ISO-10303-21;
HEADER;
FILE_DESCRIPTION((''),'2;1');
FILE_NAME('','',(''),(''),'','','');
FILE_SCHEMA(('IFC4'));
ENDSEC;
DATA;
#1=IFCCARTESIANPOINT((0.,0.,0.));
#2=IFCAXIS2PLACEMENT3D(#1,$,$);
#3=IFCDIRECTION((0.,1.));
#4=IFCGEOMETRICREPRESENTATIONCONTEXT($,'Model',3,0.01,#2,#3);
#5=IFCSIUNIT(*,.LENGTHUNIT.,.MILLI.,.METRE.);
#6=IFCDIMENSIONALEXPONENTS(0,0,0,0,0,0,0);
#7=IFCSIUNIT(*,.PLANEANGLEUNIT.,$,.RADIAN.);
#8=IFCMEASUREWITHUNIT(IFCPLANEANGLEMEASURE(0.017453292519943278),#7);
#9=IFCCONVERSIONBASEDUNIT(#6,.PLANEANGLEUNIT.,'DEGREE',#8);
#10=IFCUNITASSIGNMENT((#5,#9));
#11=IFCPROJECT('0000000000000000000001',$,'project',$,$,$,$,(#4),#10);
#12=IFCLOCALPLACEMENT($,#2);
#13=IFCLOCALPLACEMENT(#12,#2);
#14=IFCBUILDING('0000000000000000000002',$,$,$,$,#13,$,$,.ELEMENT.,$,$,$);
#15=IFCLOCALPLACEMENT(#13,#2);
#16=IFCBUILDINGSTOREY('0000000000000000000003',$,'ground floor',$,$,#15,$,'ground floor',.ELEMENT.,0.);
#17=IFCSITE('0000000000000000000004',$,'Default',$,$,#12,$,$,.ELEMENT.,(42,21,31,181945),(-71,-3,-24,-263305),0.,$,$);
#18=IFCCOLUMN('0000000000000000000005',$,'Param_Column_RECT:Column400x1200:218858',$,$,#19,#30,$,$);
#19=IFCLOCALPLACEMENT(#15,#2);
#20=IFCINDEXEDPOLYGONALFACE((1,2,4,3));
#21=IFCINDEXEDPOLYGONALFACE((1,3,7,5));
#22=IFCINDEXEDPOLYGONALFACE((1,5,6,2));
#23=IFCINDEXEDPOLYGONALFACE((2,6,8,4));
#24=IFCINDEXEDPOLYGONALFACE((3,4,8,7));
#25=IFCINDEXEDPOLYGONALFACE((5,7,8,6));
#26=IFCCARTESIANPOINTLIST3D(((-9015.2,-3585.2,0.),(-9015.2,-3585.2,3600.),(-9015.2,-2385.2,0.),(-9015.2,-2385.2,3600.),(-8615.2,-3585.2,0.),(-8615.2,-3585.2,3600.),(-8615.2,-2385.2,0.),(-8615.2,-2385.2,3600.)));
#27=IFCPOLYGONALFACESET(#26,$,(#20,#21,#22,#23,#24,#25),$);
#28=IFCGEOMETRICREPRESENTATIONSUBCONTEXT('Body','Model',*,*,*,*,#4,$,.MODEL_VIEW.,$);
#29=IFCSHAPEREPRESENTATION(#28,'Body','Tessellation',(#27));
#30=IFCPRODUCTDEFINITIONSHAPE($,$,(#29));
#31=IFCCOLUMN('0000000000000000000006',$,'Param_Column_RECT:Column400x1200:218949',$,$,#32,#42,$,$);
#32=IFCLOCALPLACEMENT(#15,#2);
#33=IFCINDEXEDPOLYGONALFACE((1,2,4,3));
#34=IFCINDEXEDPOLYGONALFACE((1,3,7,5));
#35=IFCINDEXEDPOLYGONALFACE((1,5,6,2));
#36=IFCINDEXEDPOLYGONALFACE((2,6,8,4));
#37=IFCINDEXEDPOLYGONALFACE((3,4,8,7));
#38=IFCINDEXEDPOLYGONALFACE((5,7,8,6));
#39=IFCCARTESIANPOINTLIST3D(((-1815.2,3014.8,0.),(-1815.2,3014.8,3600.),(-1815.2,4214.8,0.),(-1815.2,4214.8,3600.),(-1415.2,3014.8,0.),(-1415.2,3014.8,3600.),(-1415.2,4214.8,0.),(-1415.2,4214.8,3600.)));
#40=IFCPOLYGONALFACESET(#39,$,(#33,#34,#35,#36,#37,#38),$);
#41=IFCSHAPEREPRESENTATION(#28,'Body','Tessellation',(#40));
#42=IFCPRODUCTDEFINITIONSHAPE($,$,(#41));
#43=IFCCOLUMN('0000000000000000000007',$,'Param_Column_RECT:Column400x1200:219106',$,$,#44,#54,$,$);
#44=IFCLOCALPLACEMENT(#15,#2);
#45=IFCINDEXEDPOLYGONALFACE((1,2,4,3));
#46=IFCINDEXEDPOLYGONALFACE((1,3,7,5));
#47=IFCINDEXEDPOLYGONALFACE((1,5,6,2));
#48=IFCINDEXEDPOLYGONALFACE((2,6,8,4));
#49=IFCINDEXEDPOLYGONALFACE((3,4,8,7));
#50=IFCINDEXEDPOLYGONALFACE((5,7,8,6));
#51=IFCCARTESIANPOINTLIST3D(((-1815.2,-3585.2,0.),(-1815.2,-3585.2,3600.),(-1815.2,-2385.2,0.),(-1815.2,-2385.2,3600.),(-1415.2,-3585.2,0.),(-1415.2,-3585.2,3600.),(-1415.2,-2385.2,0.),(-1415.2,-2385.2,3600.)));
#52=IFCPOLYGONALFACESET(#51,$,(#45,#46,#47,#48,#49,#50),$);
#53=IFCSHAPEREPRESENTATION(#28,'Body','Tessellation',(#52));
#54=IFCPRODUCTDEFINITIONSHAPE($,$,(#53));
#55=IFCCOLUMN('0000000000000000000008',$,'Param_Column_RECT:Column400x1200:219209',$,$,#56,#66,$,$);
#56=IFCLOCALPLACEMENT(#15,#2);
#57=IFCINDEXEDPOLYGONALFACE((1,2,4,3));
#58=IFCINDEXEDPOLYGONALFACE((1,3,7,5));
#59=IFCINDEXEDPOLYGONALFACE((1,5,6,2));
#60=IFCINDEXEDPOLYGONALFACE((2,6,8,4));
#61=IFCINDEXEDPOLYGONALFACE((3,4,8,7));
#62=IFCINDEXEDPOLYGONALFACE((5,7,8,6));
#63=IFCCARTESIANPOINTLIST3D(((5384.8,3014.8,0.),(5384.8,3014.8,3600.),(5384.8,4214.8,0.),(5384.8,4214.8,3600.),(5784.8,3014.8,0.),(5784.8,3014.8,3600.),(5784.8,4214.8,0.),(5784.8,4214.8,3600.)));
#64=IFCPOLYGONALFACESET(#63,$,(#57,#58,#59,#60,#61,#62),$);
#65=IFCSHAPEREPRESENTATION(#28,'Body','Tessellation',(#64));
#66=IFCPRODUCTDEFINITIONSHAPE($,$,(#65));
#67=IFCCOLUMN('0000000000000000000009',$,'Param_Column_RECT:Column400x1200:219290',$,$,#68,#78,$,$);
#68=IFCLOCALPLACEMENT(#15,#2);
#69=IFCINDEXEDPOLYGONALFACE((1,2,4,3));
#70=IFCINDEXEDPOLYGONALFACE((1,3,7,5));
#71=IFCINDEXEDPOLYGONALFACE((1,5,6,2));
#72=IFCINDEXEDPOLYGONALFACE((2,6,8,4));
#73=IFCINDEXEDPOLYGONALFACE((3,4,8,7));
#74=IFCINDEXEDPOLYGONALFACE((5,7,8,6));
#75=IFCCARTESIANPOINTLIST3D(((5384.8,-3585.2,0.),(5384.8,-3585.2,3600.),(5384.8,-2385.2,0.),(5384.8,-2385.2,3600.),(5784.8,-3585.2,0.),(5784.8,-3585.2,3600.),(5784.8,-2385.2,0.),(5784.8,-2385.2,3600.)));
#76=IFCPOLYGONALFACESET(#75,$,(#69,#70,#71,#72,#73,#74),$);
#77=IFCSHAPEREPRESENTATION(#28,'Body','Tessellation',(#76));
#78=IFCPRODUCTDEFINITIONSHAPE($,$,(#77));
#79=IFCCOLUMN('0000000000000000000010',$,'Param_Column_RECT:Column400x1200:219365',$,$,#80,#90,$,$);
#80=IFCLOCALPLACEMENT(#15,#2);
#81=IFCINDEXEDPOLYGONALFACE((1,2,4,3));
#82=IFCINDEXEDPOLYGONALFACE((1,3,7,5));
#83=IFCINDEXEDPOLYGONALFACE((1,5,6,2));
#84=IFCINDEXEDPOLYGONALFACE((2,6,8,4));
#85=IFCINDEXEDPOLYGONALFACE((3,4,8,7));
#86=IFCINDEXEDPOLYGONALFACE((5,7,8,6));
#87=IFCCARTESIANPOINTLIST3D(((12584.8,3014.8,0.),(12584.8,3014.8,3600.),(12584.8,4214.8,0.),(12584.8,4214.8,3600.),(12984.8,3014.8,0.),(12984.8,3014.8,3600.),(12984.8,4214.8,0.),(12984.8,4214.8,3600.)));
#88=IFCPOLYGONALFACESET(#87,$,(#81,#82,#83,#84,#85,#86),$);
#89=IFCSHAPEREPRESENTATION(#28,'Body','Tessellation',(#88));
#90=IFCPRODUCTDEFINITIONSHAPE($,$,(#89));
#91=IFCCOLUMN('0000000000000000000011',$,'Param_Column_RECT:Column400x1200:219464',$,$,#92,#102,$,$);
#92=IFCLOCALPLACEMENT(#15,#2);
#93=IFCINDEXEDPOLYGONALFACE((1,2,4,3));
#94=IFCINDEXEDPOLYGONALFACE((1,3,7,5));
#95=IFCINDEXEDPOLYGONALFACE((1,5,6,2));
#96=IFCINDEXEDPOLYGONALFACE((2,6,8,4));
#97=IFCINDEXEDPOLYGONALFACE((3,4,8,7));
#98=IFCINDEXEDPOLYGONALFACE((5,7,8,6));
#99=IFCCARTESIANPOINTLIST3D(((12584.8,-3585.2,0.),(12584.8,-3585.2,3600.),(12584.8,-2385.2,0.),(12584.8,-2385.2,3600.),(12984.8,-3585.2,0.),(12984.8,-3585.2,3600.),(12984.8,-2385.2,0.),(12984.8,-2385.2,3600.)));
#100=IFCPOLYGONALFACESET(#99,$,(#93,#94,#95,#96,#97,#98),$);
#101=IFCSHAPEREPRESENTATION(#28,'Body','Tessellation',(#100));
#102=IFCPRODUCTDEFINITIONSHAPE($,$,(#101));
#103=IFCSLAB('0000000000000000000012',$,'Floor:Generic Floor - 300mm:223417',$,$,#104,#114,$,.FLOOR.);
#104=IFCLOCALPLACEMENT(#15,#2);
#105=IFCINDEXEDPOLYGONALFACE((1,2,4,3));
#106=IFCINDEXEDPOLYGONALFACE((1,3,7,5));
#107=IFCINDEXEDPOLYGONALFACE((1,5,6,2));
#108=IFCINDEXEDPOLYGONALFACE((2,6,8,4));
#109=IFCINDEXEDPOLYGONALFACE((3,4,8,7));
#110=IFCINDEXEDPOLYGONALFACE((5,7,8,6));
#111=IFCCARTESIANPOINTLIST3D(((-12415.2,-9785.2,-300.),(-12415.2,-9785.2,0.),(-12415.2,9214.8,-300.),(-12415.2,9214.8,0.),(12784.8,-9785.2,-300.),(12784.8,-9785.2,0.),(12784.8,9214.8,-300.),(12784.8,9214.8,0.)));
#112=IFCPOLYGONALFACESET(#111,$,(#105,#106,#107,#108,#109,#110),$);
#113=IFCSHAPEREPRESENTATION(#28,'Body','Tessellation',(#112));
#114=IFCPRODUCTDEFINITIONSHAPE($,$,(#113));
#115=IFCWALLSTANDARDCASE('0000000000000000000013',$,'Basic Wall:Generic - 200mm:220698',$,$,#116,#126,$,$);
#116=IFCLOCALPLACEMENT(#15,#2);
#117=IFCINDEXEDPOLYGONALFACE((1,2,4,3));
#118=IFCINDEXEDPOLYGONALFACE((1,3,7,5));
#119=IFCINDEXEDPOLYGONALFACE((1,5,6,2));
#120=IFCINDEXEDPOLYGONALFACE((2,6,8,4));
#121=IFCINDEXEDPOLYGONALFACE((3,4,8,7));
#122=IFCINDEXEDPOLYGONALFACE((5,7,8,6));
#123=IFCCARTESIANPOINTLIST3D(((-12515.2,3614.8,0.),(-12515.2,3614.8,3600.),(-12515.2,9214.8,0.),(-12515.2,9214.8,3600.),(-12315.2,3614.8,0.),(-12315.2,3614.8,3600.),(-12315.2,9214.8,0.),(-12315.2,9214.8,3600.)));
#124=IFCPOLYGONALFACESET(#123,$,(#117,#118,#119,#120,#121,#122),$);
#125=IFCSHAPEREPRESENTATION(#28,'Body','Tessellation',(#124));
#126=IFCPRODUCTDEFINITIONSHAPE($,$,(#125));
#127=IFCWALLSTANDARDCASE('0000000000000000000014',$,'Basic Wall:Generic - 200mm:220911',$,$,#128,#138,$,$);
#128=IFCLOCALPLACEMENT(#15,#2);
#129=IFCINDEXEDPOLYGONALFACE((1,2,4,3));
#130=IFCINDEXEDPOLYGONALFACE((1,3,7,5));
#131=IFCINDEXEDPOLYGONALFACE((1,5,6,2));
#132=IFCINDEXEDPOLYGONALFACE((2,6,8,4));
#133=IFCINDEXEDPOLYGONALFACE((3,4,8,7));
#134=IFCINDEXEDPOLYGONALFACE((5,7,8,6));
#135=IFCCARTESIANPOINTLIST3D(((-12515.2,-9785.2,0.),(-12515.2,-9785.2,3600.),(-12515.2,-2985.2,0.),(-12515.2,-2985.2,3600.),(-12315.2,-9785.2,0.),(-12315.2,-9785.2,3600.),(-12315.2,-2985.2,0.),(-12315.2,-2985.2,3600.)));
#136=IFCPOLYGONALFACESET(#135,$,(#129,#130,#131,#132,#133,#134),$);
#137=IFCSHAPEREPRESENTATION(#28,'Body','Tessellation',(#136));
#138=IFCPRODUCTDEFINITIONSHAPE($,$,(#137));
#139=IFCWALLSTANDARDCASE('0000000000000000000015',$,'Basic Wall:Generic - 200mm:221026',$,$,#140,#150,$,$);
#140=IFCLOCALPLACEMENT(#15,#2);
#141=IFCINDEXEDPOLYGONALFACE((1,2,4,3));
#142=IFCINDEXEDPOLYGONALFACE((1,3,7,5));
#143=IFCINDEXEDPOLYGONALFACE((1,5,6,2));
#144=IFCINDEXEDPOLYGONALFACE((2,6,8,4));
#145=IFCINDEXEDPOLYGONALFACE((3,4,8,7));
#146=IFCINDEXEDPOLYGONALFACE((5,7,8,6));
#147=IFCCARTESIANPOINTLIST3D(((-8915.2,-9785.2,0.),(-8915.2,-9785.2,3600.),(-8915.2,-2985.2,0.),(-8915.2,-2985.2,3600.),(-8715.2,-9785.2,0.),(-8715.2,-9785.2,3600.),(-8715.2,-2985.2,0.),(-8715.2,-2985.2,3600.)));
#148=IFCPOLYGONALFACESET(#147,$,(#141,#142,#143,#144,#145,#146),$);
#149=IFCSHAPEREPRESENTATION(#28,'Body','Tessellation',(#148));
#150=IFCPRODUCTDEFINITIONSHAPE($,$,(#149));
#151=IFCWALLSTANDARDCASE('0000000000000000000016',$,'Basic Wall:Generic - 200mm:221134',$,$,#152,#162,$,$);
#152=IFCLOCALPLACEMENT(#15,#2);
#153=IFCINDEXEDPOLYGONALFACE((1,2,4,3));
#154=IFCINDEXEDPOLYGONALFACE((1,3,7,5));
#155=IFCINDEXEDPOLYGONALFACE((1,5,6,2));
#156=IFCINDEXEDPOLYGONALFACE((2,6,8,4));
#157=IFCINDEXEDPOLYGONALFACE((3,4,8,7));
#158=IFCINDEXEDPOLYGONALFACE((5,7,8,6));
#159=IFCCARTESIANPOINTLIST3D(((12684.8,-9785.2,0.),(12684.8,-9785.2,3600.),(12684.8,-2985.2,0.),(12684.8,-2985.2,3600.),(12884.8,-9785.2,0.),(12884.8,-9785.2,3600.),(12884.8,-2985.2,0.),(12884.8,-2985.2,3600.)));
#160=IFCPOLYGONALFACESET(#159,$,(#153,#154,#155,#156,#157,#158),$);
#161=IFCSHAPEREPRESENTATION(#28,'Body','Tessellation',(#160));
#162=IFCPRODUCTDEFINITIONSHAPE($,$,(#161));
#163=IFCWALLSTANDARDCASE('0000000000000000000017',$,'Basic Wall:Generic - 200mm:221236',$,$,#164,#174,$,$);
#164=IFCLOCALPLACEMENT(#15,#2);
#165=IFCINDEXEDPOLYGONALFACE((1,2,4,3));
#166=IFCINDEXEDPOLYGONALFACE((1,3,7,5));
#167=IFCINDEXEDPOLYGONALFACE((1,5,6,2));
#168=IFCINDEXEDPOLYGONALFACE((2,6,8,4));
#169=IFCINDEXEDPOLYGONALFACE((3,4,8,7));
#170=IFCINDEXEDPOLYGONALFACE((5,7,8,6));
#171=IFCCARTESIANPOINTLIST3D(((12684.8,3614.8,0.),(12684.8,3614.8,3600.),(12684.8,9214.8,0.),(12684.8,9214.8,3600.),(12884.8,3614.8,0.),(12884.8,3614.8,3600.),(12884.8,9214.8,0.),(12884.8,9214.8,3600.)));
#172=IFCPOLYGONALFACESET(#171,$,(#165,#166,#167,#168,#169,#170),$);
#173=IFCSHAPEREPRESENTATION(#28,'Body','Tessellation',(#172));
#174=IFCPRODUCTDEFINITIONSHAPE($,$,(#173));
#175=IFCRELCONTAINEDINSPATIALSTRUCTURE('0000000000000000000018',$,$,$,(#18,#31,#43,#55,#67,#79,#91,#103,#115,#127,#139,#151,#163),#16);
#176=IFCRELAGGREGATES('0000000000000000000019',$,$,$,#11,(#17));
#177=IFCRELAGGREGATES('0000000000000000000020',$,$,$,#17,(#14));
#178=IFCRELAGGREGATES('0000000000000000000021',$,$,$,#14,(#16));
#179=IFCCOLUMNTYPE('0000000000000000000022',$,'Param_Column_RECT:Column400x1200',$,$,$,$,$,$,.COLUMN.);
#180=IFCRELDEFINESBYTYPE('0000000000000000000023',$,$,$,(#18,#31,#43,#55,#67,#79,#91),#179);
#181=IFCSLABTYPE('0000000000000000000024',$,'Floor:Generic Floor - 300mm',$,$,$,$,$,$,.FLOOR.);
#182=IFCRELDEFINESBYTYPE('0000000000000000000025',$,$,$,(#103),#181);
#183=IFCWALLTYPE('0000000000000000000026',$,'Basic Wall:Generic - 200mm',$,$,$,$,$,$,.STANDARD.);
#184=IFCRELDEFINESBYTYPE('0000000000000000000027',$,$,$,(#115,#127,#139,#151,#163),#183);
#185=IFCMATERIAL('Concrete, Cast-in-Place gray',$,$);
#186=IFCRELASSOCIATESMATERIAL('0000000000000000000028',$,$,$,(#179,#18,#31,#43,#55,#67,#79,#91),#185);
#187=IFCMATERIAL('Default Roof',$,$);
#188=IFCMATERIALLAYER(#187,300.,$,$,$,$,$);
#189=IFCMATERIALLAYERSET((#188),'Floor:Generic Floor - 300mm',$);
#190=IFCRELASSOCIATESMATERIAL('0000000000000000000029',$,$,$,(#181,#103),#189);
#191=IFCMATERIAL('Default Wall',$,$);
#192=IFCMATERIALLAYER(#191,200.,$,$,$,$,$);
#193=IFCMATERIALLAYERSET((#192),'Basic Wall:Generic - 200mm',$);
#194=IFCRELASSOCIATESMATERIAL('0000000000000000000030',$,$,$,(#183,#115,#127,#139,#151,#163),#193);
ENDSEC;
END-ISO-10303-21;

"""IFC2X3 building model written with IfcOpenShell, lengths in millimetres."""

from ifc_helpers import new_model, entity, si_unit, converted_unit, direction, frame, frame_2d, origin, origin_2d_with_axis, place, context, subcontext, project, spatial, rectangle, extrude, source, transform, mapped, material, layer, layer_set, layer_usage, type_object, type_shapes, element, save


model = new_model("IFC2X3")

# Units and contexts
model_context = context("Model", 3, precision=0.01, world=origin(), true_north=direction((0.0, 1.0)))
body_context = subcontext(model_context, "Body", "Model", "MODEL_VIEW")
ifc_project = project(units=[si_unit("LENGTHUNIT", "METRE", prefix="MILLI"), converted_unit("PLANEANGLEUNIT", "DEGREE", entity("IfcPlaneAngleMeasure", 0.017453292519943278), si_unit("PLANEANGLEUNIT", "RADIAN"), dimensions=[0, 0, 0, 0, 0, 0, 0])], contexts=[model_context])

# Site, building, storey
site_placement = place(None, origin())
site = spatial("IfcSite", under=ifc_project, at=site_placement, Name="Default", CompositionType="ELEMENT", RefLatitude=(42, 21, 31, 181945), RefLongitude=(-71, -3, -24, -263305), RefElevation=0.0)
building_placement = place(site_placement, origin())
building = spatial("IfcBuilding", under=site, at=building_placement, CompositionType="ELEMENT")
storey_placement = place(building_placement, origin())
storey = spatial("IfcBuildingStorey", under=building, at=storey_placement, Name="ground floor", LongName="ground floor", CompositionType="ELEMENT", Elevation=0.0)

# Columns
ifc_material_1 = material(Name="Concrete, Cast-in-Place gray")
column_type_1 = type_object("IfcColumnType", Name="Param_Column_RECT:Column400x1200", PredefinedType="COLUMN", material=ifc_material_1)
shared_shape_1 = source(origin(), body_context, "Body", "SweptSolid", [
    extrude(rectangle(XDim=400.0, YDim=1200.0, at=origin_2d_with_axis()), frame((0.0, 0.0, 0.0), z_axis=(0.0, 0.0, 1.0), x_axis=(-1.0, 0.0, 0.0)), (0.0, 0.0, 1.0), 3600.0),
])
type_shapes(column_type_1, [shared_shape_1])
for number, where, name in (
    (1, (-8815.2, -2985.2, 0.0), "Param_Column_RECT:Column400x1200:218858"),
    (2, (-1615.2, 3614.8, 0.0), "Param_Column_RECT:Column400x1200:218949"),
    (3, (-1615.2, -2985.2, 0.0), "Param_Column_RECT:Column400x1200:219106"),
    (4, (5584.8, 3614.8, 0.0), "Param_Column_RECT:Column400x1200:219209"),
    (5, (5584.8, -2985.2, 0.0), "Param_Column_RECT:Column400x1200:219290"),
    (6, (12784.8, 3614.8, 0.0), "Param_Column_RECT:Column400x1200:219365"),
    (7, (12784.8, -2985.2, 0.0), "Param_Column_RECT:Column400x1200:219464"),
):
    element("IfcColumn", number, at=place(storey_placement, frame(where)), inside=storey, type_object=column_type_1, material=ifc_material_1, Name=name, context=body_context, shape_type="MappedRepresentation", body=[
        mapped(shared_shape_1, transform((0.0, 0.0, 0.0), scale=1.0)),
    ])

# Slab
ifc_material_2 = material(Name="Default Roof")
ifc_layer_1 = layer(ifc_material_2, 300.0)
ifc_layer_set_1 = layer_set([ifc_layer_1], Name="Floor:Generic Floor - 300mm")
ifc_layer_usage_1 = layer_usage(ifc_layer_set_1, "AXIS3", "POSITIVE", 0.0)
slab_type = type_object("IfcSlabType", Name="Floor:Generic Floor - 300mm", PredefinedType="FLOOR", material=ifc_layer_set_1)
slab_placement = place(storey_placement, origin())
element("IfcSlab", 8, at=slab_placement, inside=storey, type_object=slab_type, material=ifc_layer_usage_1, Name="Floor:Generic Floor - 300mm:223417", PredefinedType="FLOOR", context=body_context, shape_type="SweptSolid", body=[
    extrude(rectangle(XDim=19000.0, YDim=25200.0, at=origin_2d_with_axis()), frame((184.8, -285.2, 0.0), z_axis=(0.0, 0.0, -1.0), x_axis=(0.0, 1.0, 0.0)), (0.0, 0.0, 1.0), 300.0),
])

# Walls
ifc_material_3 = material(Name="Default Wall")
ifc_layer_2 = layer(ifc_material_3, 200.0)
ifc_layer_set_2 = layer_set([ifc_layer_2], Name="Basic Wall:Generic - 200mm")
ifc_layer_usage_2 = layer_usage(ifc_layer_set_2, "AXIS2", "NEGATIVE", 100.0)
wall_type = type_object("IfcWallType", Name="Basic Wall:Generic - 200mm", PredefinedType="STANDARD", material=ifc_layer_set_2)
wall_1_placement = place(storey_placement, frame((-12415.2, 3614.8, 0.0), z_axis=(0.0, 0.0, 1.0), x_axis=(0.0, 1.0, 0.0)))
element("IfcWallStandardCase", 9, at=wall_1_placement, inside=storey, type_object=wall_type, material=ifc_layer_usage_2, Name="Basic Wall:Generic - 200mm:220698", context=body_context, shape_type="SweptSolid", body=[
    extrude(rectangle(XDim=5600.0, YDim=200.0, at=frame_2d((2800.0, 0.0), x_axis=(-1.0, 0.0))), origin(), (0.0, 0.0, 1.0), 3600.0),
])
ifc_layer_usage_3 = layer_usage(ifc_layer_set_2, "AXIS2", "NEGATIVE", 100.0)
wall_2_placement = place(storey_placement, frame((-12415.2, -9785.2, 0.0), z_axis=(0.0, 0.0, 1.0), x_axis=(0.0, 1.0, 0.0)))
element("IfcWallStandardCase", 10, at=wall_2_placement, inside=storey, type_object=wall_type, material=ifc_layer_usage_3, Name="Basic Wall:Generic - 200mm:220911", context=body_context, shape_type="SweptSolid", body=[
    extrude(rectangle(XDim=6800.0, YDim=200.0, at=frame_2d((3400.0, 0.0), x_axis=(-1.0, 0.0))), origin(), (0.0, 0.0, 1.0), 3600.0),
])
ifc_layer_usage_4 = layer_usage(ifc_layer_set_2, "AXIS2", "NEGATIVE", 100.0)
wall_3_placement = place(storey_placement, frame((-8815.2, -9785.2, 0.0), z_axis=(0.0, 0.0, 1.0), x_axis=(0.0, 1.0, 0.0)))
element("IfcWallStandardCase", 11, at=wall_3_placement, inside=storey, type_object=wall_type, material=ifc_layer_usage_4, Name="Basic Wall:Generic - 200mm:221026", context=body_context, shape_type="SweptSolid", body=[
    extrude(rectangle(XDim=6800.0, YDim=200.0, at=frame_2d((3400.0, 0.0), x_axis=(-1.0, 0.0))), origin(), (0.0, 0.0, 1.0), 3600.0),
])
ifc_layer_usage_5 = layer_usage(ifc_layer_set_2, "AXIS2", "NEGATIVE", 100.0)
wall_4_placement = place(storey_placement, frame((12784.8, -9785.2, 0.0), z_axis=(0.0, 0.0, 1.0), x_axis=(0.0, 1.0, 0.0)))
element("IfcWallStandardCase", 12, at=wall_4_placement, inside=storey, type_object=wall_type, material=ifc_layer_usage_5, Name="Basic Wall:Generic - 200mm:221134", context=body_context, shape_type="SweptSolid", body=[
    extrude(rectangle(XDim=6800.0, YDim=200.0, at=frame_2d((3400.0, 0.0), x_axis=(-1.0, 0.0))), origin(), (0.0, 0.0, 1.0), 3600.0),
])
ifc_layer_usage_6 = layer_usage(ifc_layer_set_2, "AXIS2", "NEGATIVE", 100.0)
wall_5_placement = place(storey_placement, frame((12784.8, 3614.8, 0.0), z_axis=(0.0, 0.0, 1.0), x_axis=(0.0, 1.0, 0.0)))
element("IfcWallStandardCase", 13, at=wall_5_placement, inside=storey, type_object=wall_type, material=ifc_layer_usage_6, Name="Basic Wall:Generic - 200mm:221236", context=body_context, shape_type="SweptSolid", body=[
    extrude(rectangle(XDim=5600.0, YDim=200.0, at=frame_2d((2800.0, 0.0), x_axis=(-1.0, 0.0))), origin(), (0.0, 0.0, 1.0), 3600.0),
])

save(model, "model.ifc")
